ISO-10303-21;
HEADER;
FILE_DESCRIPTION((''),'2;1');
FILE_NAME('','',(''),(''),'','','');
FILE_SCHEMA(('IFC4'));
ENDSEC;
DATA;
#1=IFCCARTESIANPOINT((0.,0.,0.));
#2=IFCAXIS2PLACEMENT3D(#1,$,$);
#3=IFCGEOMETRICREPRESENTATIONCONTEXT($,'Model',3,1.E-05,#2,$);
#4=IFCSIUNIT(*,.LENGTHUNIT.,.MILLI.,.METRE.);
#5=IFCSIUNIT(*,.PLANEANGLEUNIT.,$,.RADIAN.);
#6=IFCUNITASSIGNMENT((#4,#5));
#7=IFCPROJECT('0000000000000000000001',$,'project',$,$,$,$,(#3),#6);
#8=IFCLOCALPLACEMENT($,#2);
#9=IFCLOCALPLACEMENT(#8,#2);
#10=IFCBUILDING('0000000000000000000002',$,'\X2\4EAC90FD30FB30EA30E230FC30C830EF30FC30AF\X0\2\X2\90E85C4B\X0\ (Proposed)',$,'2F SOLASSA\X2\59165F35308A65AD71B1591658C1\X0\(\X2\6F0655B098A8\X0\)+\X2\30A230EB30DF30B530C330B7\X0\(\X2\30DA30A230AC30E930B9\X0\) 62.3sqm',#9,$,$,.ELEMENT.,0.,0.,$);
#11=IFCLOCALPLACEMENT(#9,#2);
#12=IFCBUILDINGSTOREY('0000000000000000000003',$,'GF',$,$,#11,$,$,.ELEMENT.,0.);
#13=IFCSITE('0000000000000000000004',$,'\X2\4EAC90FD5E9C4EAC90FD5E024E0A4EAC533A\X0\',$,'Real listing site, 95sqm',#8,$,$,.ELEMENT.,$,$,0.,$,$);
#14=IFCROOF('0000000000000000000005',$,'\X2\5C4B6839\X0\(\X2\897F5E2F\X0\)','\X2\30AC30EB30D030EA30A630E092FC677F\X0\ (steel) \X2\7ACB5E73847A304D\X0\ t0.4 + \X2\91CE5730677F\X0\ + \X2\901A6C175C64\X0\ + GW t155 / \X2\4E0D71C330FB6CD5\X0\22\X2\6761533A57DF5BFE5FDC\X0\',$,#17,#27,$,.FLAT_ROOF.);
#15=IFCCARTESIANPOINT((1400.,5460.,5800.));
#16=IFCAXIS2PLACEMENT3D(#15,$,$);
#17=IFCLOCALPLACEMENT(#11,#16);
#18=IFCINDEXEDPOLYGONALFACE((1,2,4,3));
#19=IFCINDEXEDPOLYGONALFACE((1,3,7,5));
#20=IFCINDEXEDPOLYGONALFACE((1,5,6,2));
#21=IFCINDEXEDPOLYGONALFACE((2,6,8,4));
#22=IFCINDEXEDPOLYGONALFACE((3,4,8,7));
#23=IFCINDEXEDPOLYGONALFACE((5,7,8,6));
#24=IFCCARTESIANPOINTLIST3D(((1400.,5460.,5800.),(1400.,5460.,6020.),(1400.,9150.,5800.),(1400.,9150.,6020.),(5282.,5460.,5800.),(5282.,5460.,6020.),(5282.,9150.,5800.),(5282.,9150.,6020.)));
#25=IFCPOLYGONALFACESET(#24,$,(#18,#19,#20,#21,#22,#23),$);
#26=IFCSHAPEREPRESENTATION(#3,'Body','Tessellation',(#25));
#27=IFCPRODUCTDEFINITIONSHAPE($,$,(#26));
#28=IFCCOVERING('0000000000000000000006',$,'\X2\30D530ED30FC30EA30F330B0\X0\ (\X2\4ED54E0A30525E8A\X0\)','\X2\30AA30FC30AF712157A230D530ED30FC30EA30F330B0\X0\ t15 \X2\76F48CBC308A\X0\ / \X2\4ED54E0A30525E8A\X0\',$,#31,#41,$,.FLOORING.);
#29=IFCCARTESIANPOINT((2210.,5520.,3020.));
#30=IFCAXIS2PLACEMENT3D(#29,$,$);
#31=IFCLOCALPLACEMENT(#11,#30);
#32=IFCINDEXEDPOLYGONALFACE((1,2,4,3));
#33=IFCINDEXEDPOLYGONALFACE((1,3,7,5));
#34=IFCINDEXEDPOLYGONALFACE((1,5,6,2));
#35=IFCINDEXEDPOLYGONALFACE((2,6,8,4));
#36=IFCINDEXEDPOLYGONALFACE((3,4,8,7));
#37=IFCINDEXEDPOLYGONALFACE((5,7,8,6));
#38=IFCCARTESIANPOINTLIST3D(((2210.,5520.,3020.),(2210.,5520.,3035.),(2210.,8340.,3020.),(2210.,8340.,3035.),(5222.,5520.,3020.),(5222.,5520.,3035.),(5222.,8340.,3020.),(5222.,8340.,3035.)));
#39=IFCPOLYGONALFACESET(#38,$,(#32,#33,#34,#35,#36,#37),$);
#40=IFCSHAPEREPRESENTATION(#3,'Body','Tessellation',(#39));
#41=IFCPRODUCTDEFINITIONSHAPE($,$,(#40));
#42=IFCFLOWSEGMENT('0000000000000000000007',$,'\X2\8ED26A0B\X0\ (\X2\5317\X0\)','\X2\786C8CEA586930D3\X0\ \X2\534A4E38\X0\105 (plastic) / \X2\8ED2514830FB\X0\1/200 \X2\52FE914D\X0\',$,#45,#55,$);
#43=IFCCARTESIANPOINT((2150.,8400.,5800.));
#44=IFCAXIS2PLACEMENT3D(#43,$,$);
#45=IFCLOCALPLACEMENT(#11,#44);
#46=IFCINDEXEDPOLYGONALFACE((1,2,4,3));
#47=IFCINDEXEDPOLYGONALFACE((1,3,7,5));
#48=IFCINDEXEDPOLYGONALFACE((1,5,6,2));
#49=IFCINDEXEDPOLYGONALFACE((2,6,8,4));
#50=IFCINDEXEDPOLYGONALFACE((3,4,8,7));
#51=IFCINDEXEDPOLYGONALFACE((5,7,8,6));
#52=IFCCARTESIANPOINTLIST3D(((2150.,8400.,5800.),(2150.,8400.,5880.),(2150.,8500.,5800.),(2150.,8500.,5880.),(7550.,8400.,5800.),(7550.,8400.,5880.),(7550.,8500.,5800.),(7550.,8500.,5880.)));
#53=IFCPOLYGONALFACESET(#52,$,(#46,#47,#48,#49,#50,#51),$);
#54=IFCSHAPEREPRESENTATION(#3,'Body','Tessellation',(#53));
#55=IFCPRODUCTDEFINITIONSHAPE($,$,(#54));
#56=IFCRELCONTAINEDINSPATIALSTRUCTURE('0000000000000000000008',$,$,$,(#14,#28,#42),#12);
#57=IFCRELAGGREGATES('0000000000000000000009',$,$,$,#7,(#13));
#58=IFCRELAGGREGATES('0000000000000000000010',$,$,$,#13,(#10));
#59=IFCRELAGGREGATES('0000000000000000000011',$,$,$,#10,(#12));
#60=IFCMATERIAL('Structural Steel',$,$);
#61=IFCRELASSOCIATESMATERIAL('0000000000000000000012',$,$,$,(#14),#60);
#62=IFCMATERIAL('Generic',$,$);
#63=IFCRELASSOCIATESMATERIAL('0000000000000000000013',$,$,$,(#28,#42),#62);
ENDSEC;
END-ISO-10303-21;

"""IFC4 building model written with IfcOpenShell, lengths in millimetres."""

from ifc_helpers import new_model, si_unit, frame, frame_2d, origin, place, context, project, spatial, rectangle, extrude, material, element, save


model = new_model("IFC4")

# Units and contexts
model_context = context("Model", 3, precision=1e-05, world=origin())
ifc_project = project(units=[si_unit("LENGTHUNIT", "METRE", prefix="MILLI"), si_unit("PLANEANGLEUNIT", "RADIAN")], contexts=[model_context])

# Site, building, storey
site_placement = place(None, origin())
site = spatial("IfcSite", under=ifc_project, at=site_placement, Name="京都府京都市上京区", ObjectType="Real listing site, 95sqm", CompositionType="ELEMENT", RefElevation=0.0)
building_placement = place(site_placement, origin())
building = spatial("IfcBuilding", under=site, at=building_placement, Name="京都・リモートワーク2部屋 (Proposed)", ObjectType="2F SOLASSA外張り断熱外壁(漆喰風)+アルミサッシ(ペアガラス) 62.3sqm", CompositionType="ELEMENT", ElevationOfRefHeight=0.0, ElevationOfTerrain=0.0)
storey_placement = place(building_placement, origin())
storey = spatial("IfcBuildingStorey", under=building, at=storey_placement, Name="GF", CompositionType="ELEMENT", Elevation=0.0)

# Roof
ifc_material_1 = material(Name="Structural Steel")
for number, where, name in (
    (1, (1400.0, 5460.0, 5800.0), "屋根(西帯)"),
):
    element("IfcRoof", number, at=place(storey_placement, frame(where)), inside=storey, material=ifc_material_1, Name=name, Description="ガルバリウム鋼板 (steel) 立平葺き t0.4 + 野地板 + 通気層 + GW t155 / 不燃・法22条区域対応", PredefinedType="FLAT_ROOF", context=model_context, shape_type="SweptSolid", body=[
        extrude(rectangle(XDim=3882.0, YDim=3690.0, at=frame_2d((1941.0, 1845.0))), frame((1400.0, 5460.0, 5800.0)), (0.0, 0.0, 1.0), 220.0),
    ])

# Covering
ifc_material_2 = material(Name="Generic")
covering_placement = place(storey_placement, frame((2210.0, 5520.0, 3020.0)))
element("IfcCovering", 2, at=covering_placement, inside=storey, material=ifc_material_2, Name="フローリング (仕上げ床)", Description="オーク無垢フローリング t15 直貼り / 仕上げ床", PredefinedType="FLOORING", context=model_context, shape_type="SweptSolid", body=[
    extrude(rectangle(XDim=3012.0, YDim=2820.0, at=frame_2d((1506.0, 1410.0))), frame((2210.0, 5520.0, 3020.0)), (0.0, 0.0, 1.0), 15.0),
])

# Flow segment
flow_segment_placement = place(storey_placement, frame((2150.0, 8400.0, 5800.0)))
element("IfcFlowSegment", 3, at=flow_segment_placement, inside=storey, material=ifc_material_2, Name="軒樋 (北)", Description="硬質塩ビ 半丸105 (plastic) / 軒先・1/200 勾配", context=model_context, shape_type="SweptSolid", body=[
    extrude(rectangle(XDim=5400.0, YDim=100.0, at=frame_2d((2700.0, 50.0))), frame((2150.0, 8400.0, 5800.0)), (0.0, 0.0, 1.0), 80.0),
])

save(model, "model.ifc")
